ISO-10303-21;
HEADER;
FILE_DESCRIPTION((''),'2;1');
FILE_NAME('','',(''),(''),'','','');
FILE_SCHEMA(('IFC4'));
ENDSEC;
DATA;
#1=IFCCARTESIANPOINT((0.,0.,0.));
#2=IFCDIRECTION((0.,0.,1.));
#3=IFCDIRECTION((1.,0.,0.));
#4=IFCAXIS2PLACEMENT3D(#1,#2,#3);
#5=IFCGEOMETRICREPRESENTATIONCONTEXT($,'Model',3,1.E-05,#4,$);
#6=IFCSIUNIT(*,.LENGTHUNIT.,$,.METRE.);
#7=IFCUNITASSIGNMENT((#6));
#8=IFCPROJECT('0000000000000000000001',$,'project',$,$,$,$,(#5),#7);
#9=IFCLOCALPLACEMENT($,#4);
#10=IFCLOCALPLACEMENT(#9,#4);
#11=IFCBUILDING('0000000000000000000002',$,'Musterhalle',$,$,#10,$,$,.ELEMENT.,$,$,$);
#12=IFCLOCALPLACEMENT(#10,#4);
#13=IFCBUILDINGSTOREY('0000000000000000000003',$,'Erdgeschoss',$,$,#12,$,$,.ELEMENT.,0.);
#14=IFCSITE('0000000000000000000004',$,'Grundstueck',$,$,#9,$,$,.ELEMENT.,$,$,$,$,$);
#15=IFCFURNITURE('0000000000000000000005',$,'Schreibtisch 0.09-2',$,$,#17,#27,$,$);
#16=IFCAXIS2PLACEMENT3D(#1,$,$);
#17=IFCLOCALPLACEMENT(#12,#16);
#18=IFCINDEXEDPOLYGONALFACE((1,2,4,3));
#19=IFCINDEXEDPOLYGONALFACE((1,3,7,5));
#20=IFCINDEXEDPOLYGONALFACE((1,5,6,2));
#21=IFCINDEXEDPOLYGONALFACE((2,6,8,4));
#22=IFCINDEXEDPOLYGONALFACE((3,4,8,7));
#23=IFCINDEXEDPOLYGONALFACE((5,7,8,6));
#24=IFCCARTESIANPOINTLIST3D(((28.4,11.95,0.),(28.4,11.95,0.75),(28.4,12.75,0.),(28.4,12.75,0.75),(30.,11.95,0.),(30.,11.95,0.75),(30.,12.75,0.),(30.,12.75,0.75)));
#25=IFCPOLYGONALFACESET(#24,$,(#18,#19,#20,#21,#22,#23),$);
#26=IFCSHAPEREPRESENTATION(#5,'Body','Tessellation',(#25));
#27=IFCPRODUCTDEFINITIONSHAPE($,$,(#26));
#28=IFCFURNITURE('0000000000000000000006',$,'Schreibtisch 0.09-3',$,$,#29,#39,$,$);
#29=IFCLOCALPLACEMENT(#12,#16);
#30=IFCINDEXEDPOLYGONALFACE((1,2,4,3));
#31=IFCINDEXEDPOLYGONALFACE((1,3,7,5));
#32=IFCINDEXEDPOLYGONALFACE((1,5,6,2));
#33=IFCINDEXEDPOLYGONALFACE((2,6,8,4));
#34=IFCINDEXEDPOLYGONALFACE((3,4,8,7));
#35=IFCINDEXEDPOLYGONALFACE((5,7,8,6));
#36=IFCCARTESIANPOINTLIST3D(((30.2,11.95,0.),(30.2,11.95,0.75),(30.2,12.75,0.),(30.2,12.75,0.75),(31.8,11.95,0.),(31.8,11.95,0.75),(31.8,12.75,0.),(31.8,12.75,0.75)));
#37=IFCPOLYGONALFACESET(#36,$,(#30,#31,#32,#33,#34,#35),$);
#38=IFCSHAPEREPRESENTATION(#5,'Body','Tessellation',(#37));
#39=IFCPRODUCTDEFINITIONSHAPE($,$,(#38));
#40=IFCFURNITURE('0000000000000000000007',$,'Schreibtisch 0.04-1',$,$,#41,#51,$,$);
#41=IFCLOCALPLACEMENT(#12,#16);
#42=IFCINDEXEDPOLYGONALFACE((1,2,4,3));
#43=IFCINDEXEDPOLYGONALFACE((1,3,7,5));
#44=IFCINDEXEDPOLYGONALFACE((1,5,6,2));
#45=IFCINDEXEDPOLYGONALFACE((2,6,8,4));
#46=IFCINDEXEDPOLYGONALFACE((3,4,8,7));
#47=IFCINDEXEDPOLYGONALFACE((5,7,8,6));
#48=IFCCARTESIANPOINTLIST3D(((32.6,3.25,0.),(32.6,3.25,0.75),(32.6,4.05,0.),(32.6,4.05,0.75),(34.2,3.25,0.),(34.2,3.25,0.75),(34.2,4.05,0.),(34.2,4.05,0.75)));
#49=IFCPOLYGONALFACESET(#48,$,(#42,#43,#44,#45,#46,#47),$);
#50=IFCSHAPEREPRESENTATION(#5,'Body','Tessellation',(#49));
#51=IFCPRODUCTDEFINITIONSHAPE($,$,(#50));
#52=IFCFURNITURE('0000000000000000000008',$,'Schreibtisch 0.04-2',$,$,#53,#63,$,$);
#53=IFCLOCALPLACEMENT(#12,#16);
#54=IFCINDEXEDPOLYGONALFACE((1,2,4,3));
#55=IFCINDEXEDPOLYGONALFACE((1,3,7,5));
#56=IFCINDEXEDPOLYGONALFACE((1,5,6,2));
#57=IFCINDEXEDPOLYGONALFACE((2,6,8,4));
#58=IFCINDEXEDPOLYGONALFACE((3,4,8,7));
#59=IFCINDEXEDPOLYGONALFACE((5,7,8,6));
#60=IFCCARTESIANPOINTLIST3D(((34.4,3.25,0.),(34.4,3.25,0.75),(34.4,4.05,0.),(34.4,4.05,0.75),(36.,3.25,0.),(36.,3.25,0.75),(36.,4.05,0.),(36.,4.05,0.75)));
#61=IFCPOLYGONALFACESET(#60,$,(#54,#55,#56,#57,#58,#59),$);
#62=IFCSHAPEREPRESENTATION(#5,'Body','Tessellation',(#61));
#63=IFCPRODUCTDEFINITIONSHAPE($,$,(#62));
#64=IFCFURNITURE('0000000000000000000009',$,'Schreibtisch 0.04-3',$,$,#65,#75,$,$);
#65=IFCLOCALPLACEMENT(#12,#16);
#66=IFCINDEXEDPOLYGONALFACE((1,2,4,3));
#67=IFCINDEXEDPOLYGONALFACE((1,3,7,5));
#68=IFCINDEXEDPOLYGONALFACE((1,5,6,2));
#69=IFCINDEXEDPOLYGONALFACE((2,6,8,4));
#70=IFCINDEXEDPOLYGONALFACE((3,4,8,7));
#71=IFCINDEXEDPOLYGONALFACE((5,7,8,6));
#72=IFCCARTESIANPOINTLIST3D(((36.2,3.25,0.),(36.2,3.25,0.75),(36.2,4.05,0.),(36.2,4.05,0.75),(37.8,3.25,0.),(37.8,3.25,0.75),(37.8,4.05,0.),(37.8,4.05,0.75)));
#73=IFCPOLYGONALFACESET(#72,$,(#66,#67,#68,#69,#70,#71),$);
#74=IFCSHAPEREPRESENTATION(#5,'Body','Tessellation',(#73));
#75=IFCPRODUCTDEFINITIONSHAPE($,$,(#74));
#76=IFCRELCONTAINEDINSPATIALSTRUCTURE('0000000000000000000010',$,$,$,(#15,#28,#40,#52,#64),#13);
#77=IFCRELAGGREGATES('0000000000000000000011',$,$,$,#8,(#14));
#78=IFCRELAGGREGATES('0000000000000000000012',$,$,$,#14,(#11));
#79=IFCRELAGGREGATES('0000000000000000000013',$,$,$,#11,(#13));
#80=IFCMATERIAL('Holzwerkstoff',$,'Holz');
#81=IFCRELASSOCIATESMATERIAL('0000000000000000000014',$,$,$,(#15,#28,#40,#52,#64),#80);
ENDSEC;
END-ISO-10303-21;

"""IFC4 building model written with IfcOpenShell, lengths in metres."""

from ifc_helpers import new_model, si_unit, frame, origin_with_axes, origin_2d, place, context, project, spatial, rectangle, extrude, material, element, save


model = new_model("IFC4")

# Units and contexts
model_context = context("Model", 3, precision=1e-05, world=origin_with_axes())
ifc_project = project(units=[si_unit("LENGTHUNIT", "METRE")], contexts=[model_context])

# Site, building, storey
site_placement = place(None, origin_with_axes())
site = spatial("IfcSite", under=ifc_project, at=site_placement, Name="Grundstueck", CompositionType="ELEMENT")
building_placement = place(site_placement, origin_with_axes())
building = spatial("IfcBuilding", under=site, at=building_placement, Name="Musterhalle", CompositionType="ELEMENT")
storey_placement = place(building_placement, origin_with_axes())
storey = spatial("IfcBuildingStorey", under=building, at=storey_placement, Name="Erdgeschoss", CompositionType="ELEMENT", Elevation=0.0)

# Shared definitions
placement = place(storey_placement, origin_with_axes())

# Shared definitions
ifc_material_1 = material(Name="Holzwerkstoff", Category="Holz")

# Furniture
element("IfcFurniture", 1, at=placement, inside=storey, material=ifc_material_1, Name="Schreibtisch 0.09-2", context=model_context, shape_type="SweptSolid", body=[
    extrude(rectangle(XDim=1.6, YDim=0.8, at=origin_2d()), frame((29.2, 12.35, 0.0), z_axis=(0.0, 0.0, 1.0), x_axis=(1.0, 0.0, 0.0)), (0.0, 0.0, 1.0), 0.75),
])
element("IfcFurniture", 2, at=placement, inside=storey, material=ifc_material_1, Name="Schreibtisch 0.09-3", context=model_context, shape_type="SweptSolid", body=[
    extrude(rectangle(XDim=1.6, YDim=0.8, at=origin_2d()), frame((31.0, 12.35, 0.0), z_axis=(0.0, 0.0, 1.0), x_axis=(1.0, 0.0, 0.0)), (0.0, 0.0, 1.0), 0.75),
])
element("IfcFurniture", 3, at=placement, inside=storey, material=ifc_material_1, Name="Schreibtisch 0.04-1", context=model_context, shape_type="SweptSolid", body=[
    extrude(rectangle(XDim=1.6, YDim=0.8, at=origin_2d()), frame((33.4, 3.65, 0.0), z_axis=(0.0, 0.0, 1.0), x_axis=(1.0, 0.0, 0.0)), (0.0, 0.0, 1.0), 0.75),
])
element("IfcFurniture", 4, at=placement, inside=storey, material=ifc_material_1, Name="Schreibtisch 0.04-2", context=model_context, shape_type="SweptSolid", body=[
    extrude(rectangle(XDim=1.6, YDim=0.8, at=origin_2d()), frame((35.2, 3.65, 0.0), z_axis=(0.0, 0.0, 1.0), x_axis=(1.0, 0.0, 0.0)), (0.0, 0.0, 1.0), 0.75),
])
element("IfcFurniture", 5, at=placement, inside=storey, material=ifc_material_1, Name="Schreibtisch 0.04-3", context=model_context, shape_type="SweptSolid", body=[
    extrude(rectangle(XDim=1.6, YDim=0.8, at=origin_2d()), frame((37.0, 3.65, 0.0), z_axis=(0.0, 0.0, 1.0), x_axis=(1.0, 0.0, 0.0)), (0.0, 0.0, 1.0), 0.75),
])

save(model, "model.ifc")
